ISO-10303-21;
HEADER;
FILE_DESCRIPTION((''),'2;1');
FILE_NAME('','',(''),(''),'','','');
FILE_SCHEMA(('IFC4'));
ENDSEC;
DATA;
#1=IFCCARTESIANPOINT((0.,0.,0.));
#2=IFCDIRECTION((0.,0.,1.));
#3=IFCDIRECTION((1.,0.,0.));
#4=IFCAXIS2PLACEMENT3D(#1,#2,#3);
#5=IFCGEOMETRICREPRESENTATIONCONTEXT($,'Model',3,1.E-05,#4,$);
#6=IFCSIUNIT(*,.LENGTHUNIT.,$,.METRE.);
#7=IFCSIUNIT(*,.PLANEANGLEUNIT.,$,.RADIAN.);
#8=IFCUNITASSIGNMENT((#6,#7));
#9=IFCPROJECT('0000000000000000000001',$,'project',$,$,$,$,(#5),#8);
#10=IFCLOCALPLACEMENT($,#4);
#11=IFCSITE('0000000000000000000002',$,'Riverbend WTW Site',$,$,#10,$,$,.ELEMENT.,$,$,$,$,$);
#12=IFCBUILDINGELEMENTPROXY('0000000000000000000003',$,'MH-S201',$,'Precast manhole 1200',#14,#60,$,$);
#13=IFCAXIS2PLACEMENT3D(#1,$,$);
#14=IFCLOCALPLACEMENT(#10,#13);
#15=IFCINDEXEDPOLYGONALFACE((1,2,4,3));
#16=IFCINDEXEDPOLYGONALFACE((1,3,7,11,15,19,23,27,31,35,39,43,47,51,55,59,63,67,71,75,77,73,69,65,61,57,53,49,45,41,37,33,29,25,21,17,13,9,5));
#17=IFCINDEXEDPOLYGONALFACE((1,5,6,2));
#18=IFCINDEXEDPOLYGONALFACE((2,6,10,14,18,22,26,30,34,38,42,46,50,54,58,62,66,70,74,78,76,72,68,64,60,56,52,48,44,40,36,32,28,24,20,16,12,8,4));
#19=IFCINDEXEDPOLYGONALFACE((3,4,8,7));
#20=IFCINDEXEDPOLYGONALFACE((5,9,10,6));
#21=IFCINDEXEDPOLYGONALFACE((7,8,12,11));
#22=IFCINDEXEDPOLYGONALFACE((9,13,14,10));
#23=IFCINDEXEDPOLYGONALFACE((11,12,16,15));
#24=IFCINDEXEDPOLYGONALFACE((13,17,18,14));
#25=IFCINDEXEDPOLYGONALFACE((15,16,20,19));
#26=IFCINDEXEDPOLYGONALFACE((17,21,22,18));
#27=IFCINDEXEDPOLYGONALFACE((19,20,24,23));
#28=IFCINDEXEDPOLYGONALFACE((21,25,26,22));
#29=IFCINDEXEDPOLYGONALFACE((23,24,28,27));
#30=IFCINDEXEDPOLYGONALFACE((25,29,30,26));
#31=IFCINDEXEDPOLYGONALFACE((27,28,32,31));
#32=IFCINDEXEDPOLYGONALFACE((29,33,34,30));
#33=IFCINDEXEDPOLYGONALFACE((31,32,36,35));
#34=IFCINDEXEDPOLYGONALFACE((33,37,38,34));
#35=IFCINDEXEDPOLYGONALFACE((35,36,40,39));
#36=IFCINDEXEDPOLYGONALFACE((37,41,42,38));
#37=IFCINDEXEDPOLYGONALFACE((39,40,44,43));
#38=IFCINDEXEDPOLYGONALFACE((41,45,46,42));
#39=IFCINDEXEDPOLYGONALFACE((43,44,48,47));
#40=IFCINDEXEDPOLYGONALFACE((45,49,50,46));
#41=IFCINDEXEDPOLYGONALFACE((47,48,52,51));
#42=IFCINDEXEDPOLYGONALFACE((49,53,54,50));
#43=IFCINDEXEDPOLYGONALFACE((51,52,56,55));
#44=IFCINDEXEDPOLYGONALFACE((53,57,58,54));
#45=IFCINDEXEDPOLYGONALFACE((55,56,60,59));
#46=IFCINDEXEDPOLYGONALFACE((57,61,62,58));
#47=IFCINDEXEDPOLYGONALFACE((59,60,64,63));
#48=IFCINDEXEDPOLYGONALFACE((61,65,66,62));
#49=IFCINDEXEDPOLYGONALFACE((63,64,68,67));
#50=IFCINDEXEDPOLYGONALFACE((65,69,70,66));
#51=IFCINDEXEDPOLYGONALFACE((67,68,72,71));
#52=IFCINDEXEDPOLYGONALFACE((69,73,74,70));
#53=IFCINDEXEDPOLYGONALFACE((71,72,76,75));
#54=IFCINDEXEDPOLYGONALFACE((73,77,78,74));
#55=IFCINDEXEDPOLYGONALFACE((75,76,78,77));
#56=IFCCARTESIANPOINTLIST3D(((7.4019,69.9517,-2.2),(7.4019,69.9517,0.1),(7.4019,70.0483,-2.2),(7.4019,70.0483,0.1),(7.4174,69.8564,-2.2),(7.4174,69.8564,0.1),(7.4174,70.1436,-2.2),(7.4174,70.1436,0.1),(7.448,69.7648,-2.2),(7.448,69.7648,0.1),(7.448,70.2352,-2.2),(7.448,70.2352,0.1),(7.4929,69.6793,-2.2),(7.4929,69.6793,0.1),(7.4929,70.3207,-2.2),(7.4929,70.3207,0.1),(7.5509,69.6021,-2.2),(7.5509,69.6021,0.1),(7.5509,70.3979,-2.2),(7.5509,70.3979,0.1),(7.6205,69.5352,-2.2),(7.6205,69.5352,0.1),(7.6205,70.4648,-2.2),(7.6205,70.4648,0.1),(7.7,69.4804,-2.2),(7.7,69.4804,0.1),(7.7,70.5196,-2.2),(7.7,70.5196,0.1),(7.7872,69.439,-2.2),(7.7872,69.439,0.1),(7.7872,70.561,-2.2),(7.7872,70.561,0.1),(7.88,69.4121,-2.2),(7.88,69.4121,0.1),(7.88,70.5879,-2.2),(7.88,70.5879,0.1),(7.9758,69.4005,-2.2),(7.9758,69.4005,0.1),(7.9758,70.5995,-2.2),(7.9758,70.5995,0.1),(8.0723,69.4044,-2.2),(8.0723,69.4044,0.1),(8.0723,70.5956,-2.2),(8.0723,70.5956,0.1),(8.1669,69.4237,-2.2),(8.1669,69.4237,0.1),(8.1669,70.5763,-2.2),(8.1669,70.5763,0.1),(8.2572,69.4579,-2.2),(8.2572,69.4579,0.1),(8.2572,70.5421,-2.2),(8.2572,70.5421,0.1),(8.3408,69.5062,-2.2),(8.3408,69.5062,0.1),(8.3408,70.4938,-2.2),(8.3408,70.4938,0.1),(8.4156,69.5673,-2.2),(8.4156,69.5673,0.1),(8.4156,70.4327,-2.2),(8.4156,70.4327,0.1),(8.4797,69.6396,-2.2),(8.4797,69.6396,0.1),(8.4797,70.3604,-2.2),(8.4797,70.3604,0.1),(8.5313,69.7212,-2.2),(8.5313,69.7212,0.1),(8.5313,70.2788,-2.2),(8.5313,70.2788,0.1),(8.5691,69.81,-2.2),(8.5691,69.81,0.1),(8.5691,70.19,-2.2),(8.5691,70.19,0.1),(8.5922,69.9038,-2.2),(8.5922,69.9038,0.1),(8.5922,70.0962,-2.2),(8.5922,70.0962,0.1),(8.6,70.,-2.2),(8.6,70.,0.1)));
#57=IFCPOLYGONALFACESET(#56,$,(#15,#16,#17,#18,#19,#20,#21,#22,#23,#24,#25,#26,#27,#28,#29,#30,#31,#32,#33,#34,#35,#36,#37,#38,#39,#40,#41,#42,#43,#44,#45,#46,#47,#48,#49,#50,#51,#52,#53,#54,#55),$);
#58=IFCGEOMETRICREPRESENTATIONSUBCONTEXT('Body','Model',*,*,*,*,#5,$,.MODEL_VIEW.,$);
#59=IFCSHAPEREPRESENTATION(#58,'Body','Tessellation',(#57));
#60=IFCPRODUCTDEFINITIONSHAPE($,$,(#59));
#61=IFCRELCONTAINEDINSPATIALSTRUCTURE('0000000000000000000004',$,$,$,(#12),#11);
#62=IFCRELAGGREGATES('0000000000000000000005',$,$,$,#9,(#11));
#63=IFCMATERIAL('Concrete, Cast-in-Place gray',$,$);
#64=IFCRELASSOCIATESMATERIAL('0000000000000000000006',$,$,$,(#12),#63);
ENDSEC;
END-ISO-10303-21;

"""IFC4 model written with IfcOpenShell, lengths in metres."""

from ifc_helpers import new_model, si_unit, frame, origin_with_axes, origin_2d, place, context, subcontext, project, spatial, circle, extrude, material, element, save


model = new_model("IFC4")

# Units and contexts
model_context = context("Model", 3, precision=1e-05, world=origin_with_axes())
body_context = subcontext(model_context, "Body", "Model", "MODEL_VIEW")
ifc_project = project(units=[si_unit("LENGTHUNIT", "METRE"), si_unit("PLANEANGLEUNIT", "RADIAN")], contexts=[model_context])

# Site
site_placement = place(None, origin_with_axes())
site = spatial("IfcSite", under=ifc_project, at=site_placement, Name="Riverbend WTW Site", CompositionType="ELEMENT")

# Shared definitions
ifc_material_1 = material(Name="Concrete, Cast-in-Place gray")

# Building element proxy
proxy_1_placement = place(None, frame((8.0, 70.0, -2.2), z_axis=(0.0, 0.0, 1.0), x_axis=(1.0, 0.0, 0.0)))
element("IfcBuildingElementProxy", 1, at=proxy_1_placement, inside=site, material=ifc_material_1, Name="MH-S201", ObjectType="Precast manhole 1200", context=body_context, shape_type="SweptSolid", body=[
    extrude(circle(Radius=0.6, at=origin_2d()), origin_with_axes(), (0.0, 0.0, 1.0), 2.3),
])

save(model, "model.ifc")
